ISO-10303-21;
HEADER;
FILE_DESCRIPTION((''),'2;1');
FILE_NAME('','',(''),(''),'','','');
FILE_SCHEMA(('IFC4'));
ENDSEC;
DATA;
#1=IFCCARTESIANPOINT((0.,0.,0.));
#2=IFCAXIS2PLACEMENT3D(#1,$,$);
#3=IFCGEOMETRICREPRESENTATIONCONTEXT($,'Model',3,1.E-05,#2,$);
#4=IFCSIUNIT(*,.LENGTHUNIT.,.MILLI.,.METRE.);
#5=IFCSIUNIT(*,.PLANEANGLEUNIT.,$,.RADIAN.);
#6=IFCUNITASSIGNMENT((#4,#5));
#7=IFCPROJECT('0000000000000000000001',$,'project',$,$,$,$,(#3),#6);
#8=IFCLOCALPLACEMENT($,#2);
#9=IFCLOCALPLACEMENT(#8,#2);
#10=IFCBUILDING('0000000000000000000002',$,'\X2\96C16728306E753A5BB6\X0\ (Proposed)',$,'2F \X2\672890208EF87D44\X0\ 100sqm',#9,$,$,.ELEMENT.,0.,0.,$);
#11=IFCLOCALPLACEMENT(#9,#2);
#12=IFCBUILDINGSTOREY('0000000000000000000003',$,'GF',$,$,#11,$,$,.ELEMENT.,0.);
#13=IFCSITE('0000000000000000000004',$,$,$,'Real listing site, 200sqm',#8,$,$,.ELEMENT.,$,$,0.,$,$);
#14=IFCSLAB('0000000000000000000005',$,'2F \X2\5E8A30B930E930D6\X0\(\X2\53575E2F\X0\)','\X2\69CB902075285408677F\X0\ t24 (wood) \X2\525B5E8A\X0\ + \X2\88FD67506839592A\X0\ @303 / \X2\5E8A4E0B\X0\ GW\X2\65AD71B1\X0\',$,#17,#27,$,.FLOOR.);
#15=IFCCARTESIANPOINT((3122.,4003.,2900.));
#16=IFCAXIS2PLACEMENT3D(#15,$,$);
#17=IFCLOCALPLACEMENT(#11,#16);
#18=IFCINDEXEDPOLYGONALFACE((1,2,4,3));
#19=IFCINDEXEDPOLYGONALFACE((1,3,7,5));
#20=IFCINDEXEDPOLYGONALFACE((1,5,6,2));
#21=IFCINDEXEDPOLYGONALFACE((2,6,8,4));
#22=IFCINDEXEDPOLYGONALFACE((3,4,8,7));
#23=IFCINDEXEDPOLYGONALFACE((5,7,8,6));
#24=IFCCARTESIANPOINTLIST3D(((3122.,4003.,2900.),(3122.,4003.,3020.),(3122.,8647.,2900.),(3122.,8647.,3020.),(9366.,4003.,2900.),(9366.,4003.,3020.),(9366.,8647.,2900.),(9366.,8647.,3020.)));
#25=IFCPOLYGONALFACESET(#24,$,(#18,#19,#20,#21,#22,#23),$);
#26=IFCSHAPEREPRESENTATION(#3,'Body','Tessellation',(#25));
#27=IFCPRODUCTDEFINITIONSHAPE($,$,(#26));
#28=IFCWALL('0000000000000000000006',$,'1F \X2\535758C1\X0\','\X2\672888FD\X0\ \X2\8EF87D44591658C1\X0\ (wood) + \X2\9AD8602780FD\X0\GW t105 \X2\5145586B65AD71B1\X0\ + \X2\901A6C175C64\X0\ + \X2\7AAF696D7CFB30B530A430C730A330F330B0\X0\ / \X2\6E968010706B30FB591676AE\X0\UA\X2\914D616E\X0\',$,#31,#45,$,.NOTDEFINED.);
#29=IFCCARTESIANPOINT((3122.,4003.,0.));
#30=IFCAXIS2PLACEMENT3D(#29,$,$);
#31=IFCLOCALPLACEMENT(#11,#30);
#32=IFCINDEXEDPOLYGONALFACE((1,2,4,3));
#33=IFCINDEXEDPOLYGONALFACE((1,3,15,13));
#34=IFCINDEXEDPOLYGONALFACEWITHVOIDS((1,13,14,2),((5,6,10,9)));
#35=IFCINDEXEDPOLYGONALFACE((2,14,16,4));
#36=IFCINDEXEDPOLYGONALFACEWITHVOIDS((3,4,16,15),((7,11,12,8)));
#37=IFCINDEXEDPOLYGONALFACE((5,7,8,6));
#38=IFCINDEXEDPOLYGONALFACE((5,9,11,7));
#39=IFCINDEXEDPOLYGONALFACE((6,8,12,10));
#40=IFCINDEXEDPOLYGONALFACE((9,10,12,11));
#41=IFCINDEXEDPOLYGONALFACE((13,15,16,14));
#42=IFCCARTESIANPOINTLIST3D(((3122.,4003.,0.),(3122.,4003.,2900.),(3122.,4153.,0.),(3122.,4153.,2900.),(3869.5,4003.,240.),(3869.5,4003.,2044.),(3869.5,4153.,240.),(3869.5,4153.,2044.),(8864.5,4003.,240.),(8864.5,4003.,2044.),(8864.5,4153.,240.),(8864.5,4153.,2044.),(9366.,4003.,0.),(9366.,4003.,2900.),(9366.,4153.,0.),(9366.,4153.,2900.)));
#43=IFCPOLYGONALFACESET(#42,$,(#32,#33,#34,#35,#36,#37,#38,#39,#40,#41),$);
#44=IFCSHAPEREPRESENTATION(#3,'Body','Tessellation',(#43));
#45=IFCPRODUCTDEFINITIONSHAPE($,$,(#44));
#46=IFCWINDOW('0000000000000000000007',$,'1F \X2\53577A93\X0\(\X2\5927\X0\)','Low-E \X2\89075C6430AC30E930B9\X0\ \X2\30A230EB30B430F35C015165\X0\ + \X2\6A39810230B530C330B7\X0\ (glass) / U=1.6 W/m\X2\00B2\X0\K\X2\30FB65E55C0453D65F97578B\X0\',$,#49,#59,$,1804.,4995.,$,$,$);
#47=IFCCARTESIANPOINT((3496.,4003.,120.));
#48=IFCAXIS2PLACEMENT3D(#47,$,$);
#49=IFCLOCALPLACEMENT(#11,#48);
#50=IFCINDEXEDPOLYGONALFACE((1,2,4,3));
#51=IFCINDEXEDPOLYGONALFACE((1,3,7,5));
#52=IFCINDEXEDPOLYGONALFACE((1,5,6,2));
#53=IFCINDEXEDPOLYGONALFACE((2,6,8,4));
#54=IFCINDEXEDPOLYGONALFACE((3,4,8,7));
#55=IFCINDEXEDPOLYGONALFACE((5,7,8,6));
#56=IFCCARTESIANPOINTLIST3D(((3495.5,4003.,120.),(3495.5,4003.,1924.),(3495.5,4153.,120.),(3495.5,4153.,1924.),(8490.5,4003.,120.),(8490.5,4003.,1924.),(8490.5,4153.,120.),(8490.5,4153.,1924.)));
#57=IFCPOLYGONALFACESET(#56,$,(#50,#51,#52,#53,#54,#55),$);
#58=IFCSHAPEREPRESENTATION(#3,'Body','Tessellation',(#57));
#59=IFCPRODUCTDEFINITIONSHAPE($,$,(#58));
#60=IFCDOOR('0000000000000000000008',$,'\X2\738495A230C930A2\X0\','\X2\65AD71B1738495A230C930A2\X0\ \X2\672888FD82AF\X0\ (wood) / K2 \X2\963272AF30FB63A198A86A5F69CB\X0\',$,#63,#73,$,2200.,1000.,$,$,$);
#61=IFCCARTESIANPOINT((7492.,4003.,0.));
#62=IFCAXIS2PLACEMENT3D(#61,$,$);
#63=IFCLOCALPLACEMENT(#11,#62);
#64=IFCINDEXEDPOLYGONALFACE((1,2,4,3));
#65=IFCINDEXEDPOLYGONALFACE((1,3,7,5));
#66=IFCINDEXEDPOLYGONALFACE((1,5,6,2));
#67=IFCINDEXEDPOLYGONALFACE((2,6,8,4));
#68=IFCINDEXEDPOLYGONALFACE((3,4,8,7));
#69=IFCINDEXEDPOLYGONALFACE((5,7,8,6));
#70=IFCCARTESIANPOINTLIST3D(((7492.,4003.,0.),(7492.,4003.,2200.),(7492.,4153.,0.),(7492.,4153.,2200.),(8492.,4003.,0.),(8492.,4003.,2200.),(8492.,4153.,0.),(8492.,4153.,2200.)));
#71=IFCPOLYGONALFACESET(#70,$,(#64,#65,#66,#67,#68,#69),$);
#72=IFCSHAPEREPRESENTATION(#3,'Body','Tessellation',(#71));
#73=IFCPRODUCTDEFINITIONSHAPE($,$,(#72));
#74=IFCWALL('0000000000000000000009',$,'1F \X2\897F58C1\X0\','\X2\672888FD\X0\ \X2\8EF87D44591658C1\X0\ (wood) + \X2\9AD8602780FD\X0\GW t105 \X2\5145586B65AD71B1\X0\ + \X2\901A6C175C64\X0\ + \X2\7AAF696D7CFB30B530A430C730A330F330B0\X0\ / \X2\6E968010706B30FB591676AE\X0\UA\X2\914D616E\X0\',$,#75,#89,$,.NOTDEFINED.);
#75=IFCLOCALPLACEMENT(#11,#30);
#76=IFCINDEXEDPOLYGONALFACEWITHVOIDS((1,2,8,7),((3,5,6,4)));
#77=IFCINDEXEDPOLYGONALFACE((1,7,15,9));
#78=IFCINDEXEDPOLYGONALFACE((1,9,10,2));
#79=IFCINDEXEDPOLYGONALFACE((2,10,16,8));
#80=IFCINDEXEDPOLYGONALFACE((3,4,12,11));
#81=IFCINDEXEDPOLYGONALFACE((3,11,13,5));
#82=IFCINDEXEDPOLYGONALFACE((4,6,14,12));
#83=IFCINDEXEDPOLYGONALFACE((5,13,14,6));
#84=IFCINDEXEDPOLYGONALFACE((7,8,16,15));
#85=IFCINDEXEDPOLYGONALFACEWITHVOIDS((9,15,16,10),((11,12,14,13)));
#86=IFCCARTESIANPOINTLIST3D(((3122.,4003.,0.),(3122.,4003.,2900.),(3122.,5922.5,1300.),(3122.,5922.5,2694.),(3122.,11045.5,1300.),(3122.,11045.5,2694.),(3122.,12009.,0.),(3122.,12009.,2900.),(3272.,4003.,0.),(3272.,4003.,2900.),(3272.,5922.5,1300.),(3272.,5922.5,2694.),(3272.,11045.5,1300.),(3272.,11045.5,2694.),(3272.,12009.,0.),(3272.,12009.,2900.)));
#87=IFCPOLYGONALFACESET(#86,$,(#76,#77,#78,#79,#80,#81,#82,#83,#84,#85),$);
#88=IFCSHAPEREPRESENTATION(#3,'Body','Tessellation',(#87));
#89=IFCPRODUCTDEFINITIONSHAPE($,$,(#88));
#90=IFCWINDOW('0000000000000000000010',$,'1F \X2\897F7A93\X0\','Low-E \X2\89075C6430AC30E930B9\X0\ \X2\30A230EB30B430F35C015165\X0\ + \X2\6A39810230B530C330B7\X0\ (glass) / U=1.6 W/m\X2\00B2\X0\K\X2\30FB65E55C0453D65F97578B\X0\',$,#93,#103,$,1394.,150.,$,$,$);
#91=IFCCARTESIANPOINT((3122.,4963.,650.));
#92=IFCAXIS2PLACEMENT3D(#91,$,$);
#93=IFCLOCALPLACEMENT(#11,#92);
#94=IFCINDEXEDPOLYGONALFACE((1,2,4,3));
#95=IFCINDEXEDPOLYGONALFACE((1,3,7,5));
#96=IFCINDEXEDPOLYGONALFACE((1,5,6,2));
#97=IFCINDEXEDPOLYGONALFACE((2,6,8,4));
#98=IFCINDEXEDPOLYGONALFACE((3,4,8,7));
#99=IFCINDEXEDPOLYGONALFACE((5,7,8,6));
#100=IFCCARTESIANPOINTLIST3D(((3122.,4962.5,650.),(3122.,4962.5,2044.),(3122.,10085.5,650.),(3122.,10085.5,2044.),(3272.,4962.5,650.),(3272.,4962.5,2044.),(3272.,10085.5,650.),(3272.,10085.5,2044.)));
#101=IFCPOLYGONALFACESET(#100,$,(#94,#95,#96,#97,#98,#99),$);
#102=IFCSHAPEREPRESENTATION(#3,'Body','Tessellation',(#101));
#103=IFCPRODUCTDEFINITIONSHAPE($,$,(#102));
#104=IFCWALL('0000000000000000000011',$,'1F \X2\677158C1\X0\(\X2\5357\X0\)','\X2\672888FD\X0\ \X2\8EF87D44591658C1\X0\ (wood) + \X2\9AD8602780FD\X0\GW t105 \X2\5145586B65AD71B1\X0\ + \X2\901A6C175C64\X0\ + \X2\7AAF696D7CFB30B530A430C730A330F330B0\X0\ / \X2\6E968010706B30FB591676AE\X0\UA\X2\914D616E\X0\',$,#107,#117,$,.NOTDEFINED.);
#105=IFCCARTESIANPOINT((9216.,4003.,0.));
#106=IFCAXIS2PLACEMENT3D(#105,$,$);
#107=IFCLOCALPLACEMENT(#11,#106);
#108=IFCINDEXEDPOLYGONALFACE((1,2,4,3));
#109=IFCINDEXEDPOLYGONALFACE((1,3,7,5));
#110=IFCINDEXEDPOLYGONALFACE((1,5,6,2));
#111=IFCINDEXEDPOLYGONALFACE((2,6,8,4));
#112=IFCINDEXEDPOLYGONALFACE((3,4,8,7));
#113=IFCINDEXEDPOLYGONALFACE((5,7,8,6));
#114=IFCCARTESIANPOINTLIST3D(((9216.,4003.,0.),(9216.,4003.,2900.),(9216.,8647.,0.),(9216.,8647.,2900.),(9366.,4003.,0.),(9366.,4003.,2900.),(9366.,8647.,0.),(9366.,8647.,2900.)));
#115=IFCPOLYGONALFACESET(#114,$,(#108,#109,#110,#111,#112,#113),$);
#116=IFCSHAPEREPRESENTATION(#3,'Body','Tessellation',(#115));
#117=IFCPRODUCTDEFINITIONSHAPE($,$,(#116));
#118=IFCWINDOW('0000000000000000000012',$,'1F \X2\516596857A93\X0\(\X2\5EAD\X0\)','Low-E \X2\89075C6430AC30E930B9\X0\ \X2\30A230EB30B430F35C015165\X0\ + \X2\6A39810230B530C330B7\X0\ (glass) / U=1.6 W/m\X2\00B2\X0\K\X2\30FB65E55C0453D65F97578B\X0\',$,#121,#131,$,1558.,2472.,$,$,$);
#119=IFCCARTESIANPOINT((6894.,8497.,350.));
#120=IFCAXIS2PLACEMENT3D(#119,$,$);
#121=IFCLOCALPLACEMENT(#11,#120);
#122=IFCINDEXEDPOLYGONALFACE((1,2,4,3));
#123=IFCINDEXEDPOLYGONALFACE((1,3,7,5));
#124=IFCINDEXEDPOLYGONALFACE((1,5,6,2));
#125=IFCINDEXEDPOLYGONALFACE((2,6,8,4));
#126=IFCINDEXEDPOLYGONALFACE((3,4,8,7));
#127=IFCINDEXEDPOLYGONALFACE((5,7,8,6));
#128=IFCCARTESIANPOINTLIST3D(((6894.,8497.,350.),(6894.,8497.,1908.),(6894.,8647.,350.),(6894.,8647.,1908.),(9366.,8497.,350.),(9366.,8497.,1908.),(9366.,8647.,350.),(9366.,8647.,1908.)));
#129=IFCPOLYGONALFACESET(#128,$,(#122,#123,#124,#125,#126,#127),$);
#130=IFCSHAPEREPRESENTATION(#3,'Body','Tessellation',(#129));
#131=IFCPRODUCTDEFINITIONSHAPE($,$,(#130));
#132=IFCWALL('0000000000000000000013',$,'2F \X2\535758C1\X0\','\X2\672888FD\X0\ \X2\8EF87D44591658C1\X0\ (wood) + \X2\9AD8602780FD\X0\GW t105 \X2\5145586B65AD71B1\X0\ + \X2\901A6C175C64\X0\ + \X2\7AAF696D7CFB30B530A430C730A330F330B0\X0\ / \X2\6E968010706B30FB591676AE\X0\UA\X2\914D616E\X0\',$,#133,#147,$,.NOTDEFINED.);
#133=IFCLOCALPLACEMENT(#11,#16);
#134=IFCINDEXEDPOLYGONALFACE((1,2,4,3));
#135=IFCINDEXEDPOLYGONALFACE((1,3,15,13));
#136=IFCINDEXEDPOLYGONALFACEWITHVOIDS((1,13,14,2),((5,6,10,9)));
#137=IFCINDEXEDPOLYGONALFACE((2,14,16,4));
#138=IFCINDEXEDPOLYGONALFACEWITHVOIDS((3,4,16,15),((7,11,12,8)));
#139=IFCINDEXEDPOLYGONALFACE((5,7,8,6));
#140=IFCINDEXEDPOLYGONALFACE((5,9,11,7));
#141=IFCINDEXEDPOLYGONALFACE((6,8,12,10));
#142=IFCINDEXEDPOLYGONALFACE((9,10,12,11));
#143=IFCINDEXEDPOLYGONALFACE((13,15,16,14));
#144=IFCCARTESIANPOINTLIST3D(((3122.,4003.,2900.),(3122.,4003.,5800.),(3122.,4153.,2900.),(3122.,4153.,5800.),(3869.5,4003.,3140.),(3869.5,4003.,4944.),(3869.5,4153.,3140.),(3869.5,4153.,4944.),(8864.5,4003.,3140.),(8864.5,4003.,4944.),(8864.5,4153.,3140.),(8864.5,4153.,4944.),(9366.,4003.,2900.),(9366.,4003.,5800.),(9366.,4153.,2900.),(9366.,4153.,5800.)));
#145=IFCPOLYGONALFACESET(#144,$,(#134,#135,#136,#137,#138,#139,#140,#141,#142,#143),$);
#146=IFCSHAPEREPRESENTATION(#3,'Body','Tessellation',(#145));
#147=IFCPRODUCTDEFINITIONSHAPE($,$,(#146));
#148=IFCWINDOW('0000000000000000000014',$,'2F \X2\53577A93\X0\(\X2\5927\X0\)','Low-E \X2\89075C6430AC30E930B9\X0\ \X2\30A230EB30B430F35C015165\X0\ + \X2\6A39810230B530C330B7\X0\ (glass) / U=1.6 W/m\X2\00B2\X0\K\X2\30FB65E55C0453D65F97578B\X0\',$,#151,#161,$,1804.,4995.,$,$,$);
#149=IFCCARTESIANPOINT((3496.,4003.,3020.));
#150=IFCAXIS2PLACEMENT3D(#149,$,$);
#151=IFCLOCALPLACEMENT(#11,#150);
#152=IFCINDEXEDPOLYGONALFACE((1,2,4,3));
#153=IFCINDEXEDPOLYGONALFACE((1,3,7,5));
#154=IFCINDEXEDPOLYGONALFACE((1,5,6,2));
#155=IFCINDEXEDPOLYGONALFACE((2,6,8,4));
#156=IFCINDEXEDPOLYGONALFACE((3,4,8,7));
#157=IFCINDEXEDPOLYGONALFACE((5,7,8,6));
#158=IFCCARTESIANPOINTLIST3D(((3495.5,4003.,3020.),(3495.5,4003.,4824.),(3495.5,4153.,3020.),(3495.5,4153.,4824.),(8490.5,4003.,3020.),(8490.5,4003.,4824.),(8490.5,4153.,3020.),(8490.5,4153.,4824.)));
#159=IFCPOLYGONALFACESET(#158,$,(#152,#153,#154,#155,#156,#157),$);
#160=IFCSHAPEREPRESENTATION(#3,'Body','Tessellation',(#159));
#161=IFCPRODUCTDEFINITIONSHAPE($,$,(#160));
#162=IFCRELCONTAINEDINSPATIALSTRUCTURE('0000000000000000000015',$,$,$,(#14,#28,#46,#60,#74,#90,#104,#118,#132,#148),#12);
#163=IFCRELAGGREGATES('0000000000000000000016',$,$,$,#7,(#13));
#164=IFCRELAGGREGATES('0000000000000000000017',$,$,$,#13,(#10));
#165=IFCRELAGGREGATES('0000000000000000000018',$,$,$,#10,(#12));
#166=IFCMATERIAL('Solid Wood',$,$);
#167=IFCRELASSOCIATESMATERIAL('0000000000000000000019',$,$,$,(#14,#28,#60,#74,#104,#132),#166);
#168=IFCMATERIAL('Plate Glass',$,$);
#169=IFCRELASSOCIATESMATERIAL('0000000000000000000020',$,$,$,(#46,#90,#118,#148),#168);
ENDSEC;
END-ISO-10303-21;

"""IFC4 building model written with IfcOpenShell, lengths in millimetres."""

from ifc_helpers import new_model, si_unit, frame, frame_2d, origin, place, context, project, spatial, rectangle, extrude, material, element, fill, save


model = new_model("IFC4")

# Units and contexts
model_context = context("Model", 3, precision=1e-05, world=origin())
ifc_project = project(units=[si_unit("LENGTHUNIT", "METRE", prefix="MILLI"), si_unit("PLANEANGLEUNIT", "RADIAN")], contexts=[model_context])

# Site, building, storey
site_placement = place(None, origin())
site = spatial("IfcSite", under=ifc_project, at=site_placement, ObjectType="Real listing site, 200sqm", CompositionType="ELEMENT", RefElevation=0.0)
building_placement = place(site_placement, origin())
building = spatial("IfcBuilding", under=site, at=building_placement, Name="雁木の町家 (Proposed)", ObjectType="2F 木造軸組 100sqm", CompositionType="ELEMENT", ElevationOfRefHeight=0.0, ElevationOfTerrain=0.0)
storey_placement = place(building_placement, origin())
storey = spatial("IfcBuildingStorey", under=building, at=storey_placement, Name="GF", CompositionType="ELEMENT", Elevation=0.0)

# Slab
ifc_material_1 = material(Name="Solid Wood")
slab_1_placement = place(storey_placement, frame((3122.0, 4003.0, 2900.0)))
element("IfcSlab", 1, at=slab_1_placement, inside=storey, material=ifc_material_1, Name="2F 床スラブ(南帯)", Description="構造用合板 t24 (wood) 剛床 + 製材根太 @303 / 床下 GW断熱", PredefinedType="FLOOR", context=model_context, shape_type="SweptSolid", body=[
    extrude(rectangle(XDim=6244.0, YDim=4644.0, at=frame_2d((3122.0, 2322.0))), frame((3122.0, 4003.0, 2900.0)), (0.0, 0.0, 1.0), 120.0),
])

# Wall, openings, window, door
wall_1_placement = place(storey_placement, frame((3122.0, 4003.0, 0.0)))
wall_1 = element("IfcWall", 2, at=wall_1_placement, inside=storey, material=ifc_material_1, Name="1F 南壁", Description="木製 軸組外壁 (wood) + 高性能GW t105 充填断熱 + 通気層 + 窯業系サイディング / 準耐火・外皮UA配慮", PredefinedType="NOTDEFINED", context=model_context, shape_type="SweptSolid", body=[
    extrude(rectangle(XDim=6244.0, YDim=150.0, at=frame_2d((3122.0, 75.0))), frame((3122.0, 4003.0, 0.0)), (0.0, 0.0, 1.0), 2900.0),
])
opening_1_placement = place(storey_placement, frame((3496.0, 4003.0, 120.0)))
opening_1 = element("IfcOpeningElement", 3, at=opening_1_placement, cuts=wall_1, PredefinedType="NOTDEFINED", context=model_context, shape_type="SweptSolid", body=[
    extrude(rectangle(XDim=4995.0, YDim=150.0, at=frame_2d((2497.0, 75.0))), frame((3496.0, 4003.0, 120.0)), (0.0, 0.0, 1.0), 1804.0),
])
opening_2_placement = place(storey_placement, frame((7492.0, 4003.0, 0.0)))
opening_2 = element("IfcOpeningElement", 4, at=opening_2_placement, cuts=wall_1, PredefinedType="NOTDEFINED", context=model_context, shape_type="SweptSolid", body=[
    extrude(rectangle(XDim=1000.0, YDim=150.0, at=frame_2d((500.0, 75.0))), frame((7492.0, 4003.0, 0.0)), (0.0, 0.0, 1.0), 2200.0),
])
ifc_material_2 = material(Name="Plate Glass")
window_1_placement = place(storey_placement, frame((3496.0, 4003.0, 120.0)))
window_1 = element("IfcWindow", 5, at=window_1_placement, inside=storey, material=ifc_material_2, Name="1F 南窓(大)", Description="Low-E 複層ガラス アルゴン封入 + 樹脂サッシ (glass) / U=1.6 W/m²K・日射取得型", OverallHeight=1804.0, OverallWidth=4995.0, context=model_context, shape_type="SweptSolid", body=[
    extrude(rectangle(XDim=4995.0, YDim=150.0, at=frame_2d((2497.0, 75.0))), frame((3496.0, 4003.0, 120.0)), (0.0, 0.0, 1.0), 1804.0),
])
fill(opening_1, window_1)
door_placement = place(storey_placement, frame((7492.0, 4003.0, 0.0)))
door = element("IfcDoor", 6, at=door_placement, inside=storey, material=ifc_material_1, Name="玄関ドア", Description="断熱玄関ドア 木製芯 (wood) / K2 防犯・採風機構", OverallHeight=2200.0, OverallWidth=1000.0, context=model_context, shape_type="SweptSolid", body=[
    extrude(rectangle(XDim=1000.0, YDim=150.0, at=frame_2d((500.0, 75.0))), frame((7492.0, 4003.0, 0.0)), (0.0, 0.0, 1.0), 2200.0),
])
fill(opening_2, door)

# Walls, openings, windows
wall_2_placement = place(storey_placement, frame((3122.0, 4003.0, 0.0)))
wall_2 = element("IfcWall", 7, at=wall_2_placement, inside=storey, material=ifc_material_1, Name="1F 西壁", Description="木製 軸組外壁 (wood) + 高性能GW t105 充填断熱 + 通気層 + 窯業系サイディング / 準耐火・外皮UA配慮", PredefinedType="NOTDEFINED", context=model_context, shape_type="SweptSolid", body=[
    extrude(rectangle(XDim=150.0, YDim=8006.0, at=frame_2d((75.0, 4003.0))), frame((3122.0, 4003.0, 0.0)), (0.0, 0.0, 1.0), 2900.0),
])
opening_3_placement = place(storey_placement, frame((3122.0, 4963.0, 650.0)))
opening_3 = element("IfcOpeningElement", 8, at=opening_3_placement, cuts=wall_2, PredefinedType="NOTDEFINED", context=model_context, shape_type="SweptSolid", body=[
    extrude(rectangle(XDim=150.0, YDim=5123.0, at=frame_2d((75.0, 2561.0))), frame((3122.0, 4963.0, 650.0)), (0.0, 0.0, 1.0), 1394.0),
])
window_2_placement = place(storey_placement, frame((3122.0, 4963.0, 650.0)))
window_2 = element("IfcWindow", 9, at=window_2_placement, inside=storey, material=ifc_material_2, Name="1F 西窓", Description="Low-E 複層ガラス アルゴン封入 + 樹脂サッシ (glass) / U=1.6 W/m²K・日射取得型", OverallHeight=1394.0, OverallWidth=150.0, context=model_context, shape_type="SweptSolid", body=[
    extrude(rectangle(XDim=150.0, YDim=5123.0, at=frame_2d((75.0, 2561.0))), frame((3122.0, 4963.0, 650.0)), (0.0, 0.0, 1.0), 1394.0),
])
fill(opening_3, window_2)
wall_3_placement = place(storey_placement, frame((9216.0, 4003.0, 0.0)))
wall_3 = element("IfcWall", 10, at=wall_3_placement, inside=storey, material=ifc_material_1, Name="1F 東壁(南)", Description="木製 軸組外壁 (wood) + 高性能GW t105 充填断熱 + 通気層 + 窯業系サイディング / 準耐火・外皮UA配慮", PredefinedType="NOTDEFINED", context=model_context, shape_type="SweptSolid", body=[
    extrude(rectangle(XDim=150.0, YDim=4644.0, at=frame_2d((75.0, 2322.0))), frame((9216.0, 4003.0, 0.0)), (0.0, 0.0, 1.0), 2900.0),
])
opening_4_placement = place(storey_placement, frame((6894.0, 8497.0, 350.0)))
opening_4 = element("IfcOpeningElement", 11, at=opening_4_placement, cuts=wall_3, PredefinedType="NOTDEFINED", context=model_context, shape_type="SweptSolid", body=[
    extrude(rectangle(XDim=2472.0, YDim=150.0, at=frame_2d((1236.0, 75.0))), frame((6894.0, 8497.0, 350.0)), (0.0, 0.0, 1.0), 1558.0),
])
window_3_placement = place(storey_placement, frame((6894.0, 8497.0, 350.0)))
window_3 = element("IfcWindow", 12, at=window_3_placement, inside=storey, material=ifc_material_2, Name="1F 入隅窓(庭)", Description="Low-E 複層ガラス アルゴン封入 + 樹脂サッシ (glass) / U=1.6 W/m²K・日射取得型", OverallHeight=1558.0, OverallWidth=2472.0, context=model_context, shape_type="SweptSolid", body=[
    extrude(rectangle(XDim=2472.0, YDim=150.0, at=frame_2d((1236.0, 75.0))), frame((6894.0, 8497.0, 350.0)), (0.0, 0.0, 1.0), 1558.0),
])
fill(opening_4, window_3)

# Wall, opening, window
wall_4_placement = place(storey_placement, frame((3122.0, 4003.0, 2900.0)))
wall_4 = element("IfcWall", 13, at=wall_4_placement, inside=storey, material=ifc_material_1, Name="2F 南壁", Description="木製 軸組外壁 (wood) + 高性能GW t105 充填断熱 + 通気層 + 窯業系サイディング / 準耐火・外皮UA配慮", PredefinedType="NOTDEFINED", context=model_context, shape_type="SweptSolid", body=[
    extrude(rectangle(XDim=6244.0, YDim=150.0, at=frame_2d((3122.0, 75.0))), frame((3122.0, 4003.0, 2900.0)), (0.0, 0.0, 1.0), 2900.0),
])
opening_5_placement = place(storey_placement, frame((3496.0, 4003.0, 3020.0)))
opening_5 = element("IfcOpeningElement", 14, at=opening_5_placement, cuts=wall_4, PredefinedType="NOTDEFINED", context=model_context, shape_type="SweptSolid", body=[
    extrude(rectangle(XDim=4995.0, YDim=150.0, at=frame_2d((2497.0, 75.0))), frame((3496.0, 4003.0, 3020.0)), (0.0, 0.0, 1.0), 1804.0),
])
window_4_placement = place(storey_placement, frame((3496.0, 4003.0, 3020.0)))
window_4 = element("IfcWindow", 15, at=window_4_placement, inside=storey, material=ifc_material_2, Name="2F 南窓(大)", Description="Low-E 複層ガラス アルゴン封入 + 樹脂サッシ (glass) / U=1.6 W/m²K・日射取得型", OverallHeight=1804.0, OverallWidth=4995.0, context=model_context, shape_type="SweptSolid", body=[
    extrude(rectangle(XDim=4995.0, YDim=150.0, at=frame_2d((2497.0, 75.0))), frame((3496.0, 4003.0, 3020.0)), (0.0, 0.0, 1.0), 1804.0),
])
fill(opening_5, window_4)

save(model, "model.ifc")
